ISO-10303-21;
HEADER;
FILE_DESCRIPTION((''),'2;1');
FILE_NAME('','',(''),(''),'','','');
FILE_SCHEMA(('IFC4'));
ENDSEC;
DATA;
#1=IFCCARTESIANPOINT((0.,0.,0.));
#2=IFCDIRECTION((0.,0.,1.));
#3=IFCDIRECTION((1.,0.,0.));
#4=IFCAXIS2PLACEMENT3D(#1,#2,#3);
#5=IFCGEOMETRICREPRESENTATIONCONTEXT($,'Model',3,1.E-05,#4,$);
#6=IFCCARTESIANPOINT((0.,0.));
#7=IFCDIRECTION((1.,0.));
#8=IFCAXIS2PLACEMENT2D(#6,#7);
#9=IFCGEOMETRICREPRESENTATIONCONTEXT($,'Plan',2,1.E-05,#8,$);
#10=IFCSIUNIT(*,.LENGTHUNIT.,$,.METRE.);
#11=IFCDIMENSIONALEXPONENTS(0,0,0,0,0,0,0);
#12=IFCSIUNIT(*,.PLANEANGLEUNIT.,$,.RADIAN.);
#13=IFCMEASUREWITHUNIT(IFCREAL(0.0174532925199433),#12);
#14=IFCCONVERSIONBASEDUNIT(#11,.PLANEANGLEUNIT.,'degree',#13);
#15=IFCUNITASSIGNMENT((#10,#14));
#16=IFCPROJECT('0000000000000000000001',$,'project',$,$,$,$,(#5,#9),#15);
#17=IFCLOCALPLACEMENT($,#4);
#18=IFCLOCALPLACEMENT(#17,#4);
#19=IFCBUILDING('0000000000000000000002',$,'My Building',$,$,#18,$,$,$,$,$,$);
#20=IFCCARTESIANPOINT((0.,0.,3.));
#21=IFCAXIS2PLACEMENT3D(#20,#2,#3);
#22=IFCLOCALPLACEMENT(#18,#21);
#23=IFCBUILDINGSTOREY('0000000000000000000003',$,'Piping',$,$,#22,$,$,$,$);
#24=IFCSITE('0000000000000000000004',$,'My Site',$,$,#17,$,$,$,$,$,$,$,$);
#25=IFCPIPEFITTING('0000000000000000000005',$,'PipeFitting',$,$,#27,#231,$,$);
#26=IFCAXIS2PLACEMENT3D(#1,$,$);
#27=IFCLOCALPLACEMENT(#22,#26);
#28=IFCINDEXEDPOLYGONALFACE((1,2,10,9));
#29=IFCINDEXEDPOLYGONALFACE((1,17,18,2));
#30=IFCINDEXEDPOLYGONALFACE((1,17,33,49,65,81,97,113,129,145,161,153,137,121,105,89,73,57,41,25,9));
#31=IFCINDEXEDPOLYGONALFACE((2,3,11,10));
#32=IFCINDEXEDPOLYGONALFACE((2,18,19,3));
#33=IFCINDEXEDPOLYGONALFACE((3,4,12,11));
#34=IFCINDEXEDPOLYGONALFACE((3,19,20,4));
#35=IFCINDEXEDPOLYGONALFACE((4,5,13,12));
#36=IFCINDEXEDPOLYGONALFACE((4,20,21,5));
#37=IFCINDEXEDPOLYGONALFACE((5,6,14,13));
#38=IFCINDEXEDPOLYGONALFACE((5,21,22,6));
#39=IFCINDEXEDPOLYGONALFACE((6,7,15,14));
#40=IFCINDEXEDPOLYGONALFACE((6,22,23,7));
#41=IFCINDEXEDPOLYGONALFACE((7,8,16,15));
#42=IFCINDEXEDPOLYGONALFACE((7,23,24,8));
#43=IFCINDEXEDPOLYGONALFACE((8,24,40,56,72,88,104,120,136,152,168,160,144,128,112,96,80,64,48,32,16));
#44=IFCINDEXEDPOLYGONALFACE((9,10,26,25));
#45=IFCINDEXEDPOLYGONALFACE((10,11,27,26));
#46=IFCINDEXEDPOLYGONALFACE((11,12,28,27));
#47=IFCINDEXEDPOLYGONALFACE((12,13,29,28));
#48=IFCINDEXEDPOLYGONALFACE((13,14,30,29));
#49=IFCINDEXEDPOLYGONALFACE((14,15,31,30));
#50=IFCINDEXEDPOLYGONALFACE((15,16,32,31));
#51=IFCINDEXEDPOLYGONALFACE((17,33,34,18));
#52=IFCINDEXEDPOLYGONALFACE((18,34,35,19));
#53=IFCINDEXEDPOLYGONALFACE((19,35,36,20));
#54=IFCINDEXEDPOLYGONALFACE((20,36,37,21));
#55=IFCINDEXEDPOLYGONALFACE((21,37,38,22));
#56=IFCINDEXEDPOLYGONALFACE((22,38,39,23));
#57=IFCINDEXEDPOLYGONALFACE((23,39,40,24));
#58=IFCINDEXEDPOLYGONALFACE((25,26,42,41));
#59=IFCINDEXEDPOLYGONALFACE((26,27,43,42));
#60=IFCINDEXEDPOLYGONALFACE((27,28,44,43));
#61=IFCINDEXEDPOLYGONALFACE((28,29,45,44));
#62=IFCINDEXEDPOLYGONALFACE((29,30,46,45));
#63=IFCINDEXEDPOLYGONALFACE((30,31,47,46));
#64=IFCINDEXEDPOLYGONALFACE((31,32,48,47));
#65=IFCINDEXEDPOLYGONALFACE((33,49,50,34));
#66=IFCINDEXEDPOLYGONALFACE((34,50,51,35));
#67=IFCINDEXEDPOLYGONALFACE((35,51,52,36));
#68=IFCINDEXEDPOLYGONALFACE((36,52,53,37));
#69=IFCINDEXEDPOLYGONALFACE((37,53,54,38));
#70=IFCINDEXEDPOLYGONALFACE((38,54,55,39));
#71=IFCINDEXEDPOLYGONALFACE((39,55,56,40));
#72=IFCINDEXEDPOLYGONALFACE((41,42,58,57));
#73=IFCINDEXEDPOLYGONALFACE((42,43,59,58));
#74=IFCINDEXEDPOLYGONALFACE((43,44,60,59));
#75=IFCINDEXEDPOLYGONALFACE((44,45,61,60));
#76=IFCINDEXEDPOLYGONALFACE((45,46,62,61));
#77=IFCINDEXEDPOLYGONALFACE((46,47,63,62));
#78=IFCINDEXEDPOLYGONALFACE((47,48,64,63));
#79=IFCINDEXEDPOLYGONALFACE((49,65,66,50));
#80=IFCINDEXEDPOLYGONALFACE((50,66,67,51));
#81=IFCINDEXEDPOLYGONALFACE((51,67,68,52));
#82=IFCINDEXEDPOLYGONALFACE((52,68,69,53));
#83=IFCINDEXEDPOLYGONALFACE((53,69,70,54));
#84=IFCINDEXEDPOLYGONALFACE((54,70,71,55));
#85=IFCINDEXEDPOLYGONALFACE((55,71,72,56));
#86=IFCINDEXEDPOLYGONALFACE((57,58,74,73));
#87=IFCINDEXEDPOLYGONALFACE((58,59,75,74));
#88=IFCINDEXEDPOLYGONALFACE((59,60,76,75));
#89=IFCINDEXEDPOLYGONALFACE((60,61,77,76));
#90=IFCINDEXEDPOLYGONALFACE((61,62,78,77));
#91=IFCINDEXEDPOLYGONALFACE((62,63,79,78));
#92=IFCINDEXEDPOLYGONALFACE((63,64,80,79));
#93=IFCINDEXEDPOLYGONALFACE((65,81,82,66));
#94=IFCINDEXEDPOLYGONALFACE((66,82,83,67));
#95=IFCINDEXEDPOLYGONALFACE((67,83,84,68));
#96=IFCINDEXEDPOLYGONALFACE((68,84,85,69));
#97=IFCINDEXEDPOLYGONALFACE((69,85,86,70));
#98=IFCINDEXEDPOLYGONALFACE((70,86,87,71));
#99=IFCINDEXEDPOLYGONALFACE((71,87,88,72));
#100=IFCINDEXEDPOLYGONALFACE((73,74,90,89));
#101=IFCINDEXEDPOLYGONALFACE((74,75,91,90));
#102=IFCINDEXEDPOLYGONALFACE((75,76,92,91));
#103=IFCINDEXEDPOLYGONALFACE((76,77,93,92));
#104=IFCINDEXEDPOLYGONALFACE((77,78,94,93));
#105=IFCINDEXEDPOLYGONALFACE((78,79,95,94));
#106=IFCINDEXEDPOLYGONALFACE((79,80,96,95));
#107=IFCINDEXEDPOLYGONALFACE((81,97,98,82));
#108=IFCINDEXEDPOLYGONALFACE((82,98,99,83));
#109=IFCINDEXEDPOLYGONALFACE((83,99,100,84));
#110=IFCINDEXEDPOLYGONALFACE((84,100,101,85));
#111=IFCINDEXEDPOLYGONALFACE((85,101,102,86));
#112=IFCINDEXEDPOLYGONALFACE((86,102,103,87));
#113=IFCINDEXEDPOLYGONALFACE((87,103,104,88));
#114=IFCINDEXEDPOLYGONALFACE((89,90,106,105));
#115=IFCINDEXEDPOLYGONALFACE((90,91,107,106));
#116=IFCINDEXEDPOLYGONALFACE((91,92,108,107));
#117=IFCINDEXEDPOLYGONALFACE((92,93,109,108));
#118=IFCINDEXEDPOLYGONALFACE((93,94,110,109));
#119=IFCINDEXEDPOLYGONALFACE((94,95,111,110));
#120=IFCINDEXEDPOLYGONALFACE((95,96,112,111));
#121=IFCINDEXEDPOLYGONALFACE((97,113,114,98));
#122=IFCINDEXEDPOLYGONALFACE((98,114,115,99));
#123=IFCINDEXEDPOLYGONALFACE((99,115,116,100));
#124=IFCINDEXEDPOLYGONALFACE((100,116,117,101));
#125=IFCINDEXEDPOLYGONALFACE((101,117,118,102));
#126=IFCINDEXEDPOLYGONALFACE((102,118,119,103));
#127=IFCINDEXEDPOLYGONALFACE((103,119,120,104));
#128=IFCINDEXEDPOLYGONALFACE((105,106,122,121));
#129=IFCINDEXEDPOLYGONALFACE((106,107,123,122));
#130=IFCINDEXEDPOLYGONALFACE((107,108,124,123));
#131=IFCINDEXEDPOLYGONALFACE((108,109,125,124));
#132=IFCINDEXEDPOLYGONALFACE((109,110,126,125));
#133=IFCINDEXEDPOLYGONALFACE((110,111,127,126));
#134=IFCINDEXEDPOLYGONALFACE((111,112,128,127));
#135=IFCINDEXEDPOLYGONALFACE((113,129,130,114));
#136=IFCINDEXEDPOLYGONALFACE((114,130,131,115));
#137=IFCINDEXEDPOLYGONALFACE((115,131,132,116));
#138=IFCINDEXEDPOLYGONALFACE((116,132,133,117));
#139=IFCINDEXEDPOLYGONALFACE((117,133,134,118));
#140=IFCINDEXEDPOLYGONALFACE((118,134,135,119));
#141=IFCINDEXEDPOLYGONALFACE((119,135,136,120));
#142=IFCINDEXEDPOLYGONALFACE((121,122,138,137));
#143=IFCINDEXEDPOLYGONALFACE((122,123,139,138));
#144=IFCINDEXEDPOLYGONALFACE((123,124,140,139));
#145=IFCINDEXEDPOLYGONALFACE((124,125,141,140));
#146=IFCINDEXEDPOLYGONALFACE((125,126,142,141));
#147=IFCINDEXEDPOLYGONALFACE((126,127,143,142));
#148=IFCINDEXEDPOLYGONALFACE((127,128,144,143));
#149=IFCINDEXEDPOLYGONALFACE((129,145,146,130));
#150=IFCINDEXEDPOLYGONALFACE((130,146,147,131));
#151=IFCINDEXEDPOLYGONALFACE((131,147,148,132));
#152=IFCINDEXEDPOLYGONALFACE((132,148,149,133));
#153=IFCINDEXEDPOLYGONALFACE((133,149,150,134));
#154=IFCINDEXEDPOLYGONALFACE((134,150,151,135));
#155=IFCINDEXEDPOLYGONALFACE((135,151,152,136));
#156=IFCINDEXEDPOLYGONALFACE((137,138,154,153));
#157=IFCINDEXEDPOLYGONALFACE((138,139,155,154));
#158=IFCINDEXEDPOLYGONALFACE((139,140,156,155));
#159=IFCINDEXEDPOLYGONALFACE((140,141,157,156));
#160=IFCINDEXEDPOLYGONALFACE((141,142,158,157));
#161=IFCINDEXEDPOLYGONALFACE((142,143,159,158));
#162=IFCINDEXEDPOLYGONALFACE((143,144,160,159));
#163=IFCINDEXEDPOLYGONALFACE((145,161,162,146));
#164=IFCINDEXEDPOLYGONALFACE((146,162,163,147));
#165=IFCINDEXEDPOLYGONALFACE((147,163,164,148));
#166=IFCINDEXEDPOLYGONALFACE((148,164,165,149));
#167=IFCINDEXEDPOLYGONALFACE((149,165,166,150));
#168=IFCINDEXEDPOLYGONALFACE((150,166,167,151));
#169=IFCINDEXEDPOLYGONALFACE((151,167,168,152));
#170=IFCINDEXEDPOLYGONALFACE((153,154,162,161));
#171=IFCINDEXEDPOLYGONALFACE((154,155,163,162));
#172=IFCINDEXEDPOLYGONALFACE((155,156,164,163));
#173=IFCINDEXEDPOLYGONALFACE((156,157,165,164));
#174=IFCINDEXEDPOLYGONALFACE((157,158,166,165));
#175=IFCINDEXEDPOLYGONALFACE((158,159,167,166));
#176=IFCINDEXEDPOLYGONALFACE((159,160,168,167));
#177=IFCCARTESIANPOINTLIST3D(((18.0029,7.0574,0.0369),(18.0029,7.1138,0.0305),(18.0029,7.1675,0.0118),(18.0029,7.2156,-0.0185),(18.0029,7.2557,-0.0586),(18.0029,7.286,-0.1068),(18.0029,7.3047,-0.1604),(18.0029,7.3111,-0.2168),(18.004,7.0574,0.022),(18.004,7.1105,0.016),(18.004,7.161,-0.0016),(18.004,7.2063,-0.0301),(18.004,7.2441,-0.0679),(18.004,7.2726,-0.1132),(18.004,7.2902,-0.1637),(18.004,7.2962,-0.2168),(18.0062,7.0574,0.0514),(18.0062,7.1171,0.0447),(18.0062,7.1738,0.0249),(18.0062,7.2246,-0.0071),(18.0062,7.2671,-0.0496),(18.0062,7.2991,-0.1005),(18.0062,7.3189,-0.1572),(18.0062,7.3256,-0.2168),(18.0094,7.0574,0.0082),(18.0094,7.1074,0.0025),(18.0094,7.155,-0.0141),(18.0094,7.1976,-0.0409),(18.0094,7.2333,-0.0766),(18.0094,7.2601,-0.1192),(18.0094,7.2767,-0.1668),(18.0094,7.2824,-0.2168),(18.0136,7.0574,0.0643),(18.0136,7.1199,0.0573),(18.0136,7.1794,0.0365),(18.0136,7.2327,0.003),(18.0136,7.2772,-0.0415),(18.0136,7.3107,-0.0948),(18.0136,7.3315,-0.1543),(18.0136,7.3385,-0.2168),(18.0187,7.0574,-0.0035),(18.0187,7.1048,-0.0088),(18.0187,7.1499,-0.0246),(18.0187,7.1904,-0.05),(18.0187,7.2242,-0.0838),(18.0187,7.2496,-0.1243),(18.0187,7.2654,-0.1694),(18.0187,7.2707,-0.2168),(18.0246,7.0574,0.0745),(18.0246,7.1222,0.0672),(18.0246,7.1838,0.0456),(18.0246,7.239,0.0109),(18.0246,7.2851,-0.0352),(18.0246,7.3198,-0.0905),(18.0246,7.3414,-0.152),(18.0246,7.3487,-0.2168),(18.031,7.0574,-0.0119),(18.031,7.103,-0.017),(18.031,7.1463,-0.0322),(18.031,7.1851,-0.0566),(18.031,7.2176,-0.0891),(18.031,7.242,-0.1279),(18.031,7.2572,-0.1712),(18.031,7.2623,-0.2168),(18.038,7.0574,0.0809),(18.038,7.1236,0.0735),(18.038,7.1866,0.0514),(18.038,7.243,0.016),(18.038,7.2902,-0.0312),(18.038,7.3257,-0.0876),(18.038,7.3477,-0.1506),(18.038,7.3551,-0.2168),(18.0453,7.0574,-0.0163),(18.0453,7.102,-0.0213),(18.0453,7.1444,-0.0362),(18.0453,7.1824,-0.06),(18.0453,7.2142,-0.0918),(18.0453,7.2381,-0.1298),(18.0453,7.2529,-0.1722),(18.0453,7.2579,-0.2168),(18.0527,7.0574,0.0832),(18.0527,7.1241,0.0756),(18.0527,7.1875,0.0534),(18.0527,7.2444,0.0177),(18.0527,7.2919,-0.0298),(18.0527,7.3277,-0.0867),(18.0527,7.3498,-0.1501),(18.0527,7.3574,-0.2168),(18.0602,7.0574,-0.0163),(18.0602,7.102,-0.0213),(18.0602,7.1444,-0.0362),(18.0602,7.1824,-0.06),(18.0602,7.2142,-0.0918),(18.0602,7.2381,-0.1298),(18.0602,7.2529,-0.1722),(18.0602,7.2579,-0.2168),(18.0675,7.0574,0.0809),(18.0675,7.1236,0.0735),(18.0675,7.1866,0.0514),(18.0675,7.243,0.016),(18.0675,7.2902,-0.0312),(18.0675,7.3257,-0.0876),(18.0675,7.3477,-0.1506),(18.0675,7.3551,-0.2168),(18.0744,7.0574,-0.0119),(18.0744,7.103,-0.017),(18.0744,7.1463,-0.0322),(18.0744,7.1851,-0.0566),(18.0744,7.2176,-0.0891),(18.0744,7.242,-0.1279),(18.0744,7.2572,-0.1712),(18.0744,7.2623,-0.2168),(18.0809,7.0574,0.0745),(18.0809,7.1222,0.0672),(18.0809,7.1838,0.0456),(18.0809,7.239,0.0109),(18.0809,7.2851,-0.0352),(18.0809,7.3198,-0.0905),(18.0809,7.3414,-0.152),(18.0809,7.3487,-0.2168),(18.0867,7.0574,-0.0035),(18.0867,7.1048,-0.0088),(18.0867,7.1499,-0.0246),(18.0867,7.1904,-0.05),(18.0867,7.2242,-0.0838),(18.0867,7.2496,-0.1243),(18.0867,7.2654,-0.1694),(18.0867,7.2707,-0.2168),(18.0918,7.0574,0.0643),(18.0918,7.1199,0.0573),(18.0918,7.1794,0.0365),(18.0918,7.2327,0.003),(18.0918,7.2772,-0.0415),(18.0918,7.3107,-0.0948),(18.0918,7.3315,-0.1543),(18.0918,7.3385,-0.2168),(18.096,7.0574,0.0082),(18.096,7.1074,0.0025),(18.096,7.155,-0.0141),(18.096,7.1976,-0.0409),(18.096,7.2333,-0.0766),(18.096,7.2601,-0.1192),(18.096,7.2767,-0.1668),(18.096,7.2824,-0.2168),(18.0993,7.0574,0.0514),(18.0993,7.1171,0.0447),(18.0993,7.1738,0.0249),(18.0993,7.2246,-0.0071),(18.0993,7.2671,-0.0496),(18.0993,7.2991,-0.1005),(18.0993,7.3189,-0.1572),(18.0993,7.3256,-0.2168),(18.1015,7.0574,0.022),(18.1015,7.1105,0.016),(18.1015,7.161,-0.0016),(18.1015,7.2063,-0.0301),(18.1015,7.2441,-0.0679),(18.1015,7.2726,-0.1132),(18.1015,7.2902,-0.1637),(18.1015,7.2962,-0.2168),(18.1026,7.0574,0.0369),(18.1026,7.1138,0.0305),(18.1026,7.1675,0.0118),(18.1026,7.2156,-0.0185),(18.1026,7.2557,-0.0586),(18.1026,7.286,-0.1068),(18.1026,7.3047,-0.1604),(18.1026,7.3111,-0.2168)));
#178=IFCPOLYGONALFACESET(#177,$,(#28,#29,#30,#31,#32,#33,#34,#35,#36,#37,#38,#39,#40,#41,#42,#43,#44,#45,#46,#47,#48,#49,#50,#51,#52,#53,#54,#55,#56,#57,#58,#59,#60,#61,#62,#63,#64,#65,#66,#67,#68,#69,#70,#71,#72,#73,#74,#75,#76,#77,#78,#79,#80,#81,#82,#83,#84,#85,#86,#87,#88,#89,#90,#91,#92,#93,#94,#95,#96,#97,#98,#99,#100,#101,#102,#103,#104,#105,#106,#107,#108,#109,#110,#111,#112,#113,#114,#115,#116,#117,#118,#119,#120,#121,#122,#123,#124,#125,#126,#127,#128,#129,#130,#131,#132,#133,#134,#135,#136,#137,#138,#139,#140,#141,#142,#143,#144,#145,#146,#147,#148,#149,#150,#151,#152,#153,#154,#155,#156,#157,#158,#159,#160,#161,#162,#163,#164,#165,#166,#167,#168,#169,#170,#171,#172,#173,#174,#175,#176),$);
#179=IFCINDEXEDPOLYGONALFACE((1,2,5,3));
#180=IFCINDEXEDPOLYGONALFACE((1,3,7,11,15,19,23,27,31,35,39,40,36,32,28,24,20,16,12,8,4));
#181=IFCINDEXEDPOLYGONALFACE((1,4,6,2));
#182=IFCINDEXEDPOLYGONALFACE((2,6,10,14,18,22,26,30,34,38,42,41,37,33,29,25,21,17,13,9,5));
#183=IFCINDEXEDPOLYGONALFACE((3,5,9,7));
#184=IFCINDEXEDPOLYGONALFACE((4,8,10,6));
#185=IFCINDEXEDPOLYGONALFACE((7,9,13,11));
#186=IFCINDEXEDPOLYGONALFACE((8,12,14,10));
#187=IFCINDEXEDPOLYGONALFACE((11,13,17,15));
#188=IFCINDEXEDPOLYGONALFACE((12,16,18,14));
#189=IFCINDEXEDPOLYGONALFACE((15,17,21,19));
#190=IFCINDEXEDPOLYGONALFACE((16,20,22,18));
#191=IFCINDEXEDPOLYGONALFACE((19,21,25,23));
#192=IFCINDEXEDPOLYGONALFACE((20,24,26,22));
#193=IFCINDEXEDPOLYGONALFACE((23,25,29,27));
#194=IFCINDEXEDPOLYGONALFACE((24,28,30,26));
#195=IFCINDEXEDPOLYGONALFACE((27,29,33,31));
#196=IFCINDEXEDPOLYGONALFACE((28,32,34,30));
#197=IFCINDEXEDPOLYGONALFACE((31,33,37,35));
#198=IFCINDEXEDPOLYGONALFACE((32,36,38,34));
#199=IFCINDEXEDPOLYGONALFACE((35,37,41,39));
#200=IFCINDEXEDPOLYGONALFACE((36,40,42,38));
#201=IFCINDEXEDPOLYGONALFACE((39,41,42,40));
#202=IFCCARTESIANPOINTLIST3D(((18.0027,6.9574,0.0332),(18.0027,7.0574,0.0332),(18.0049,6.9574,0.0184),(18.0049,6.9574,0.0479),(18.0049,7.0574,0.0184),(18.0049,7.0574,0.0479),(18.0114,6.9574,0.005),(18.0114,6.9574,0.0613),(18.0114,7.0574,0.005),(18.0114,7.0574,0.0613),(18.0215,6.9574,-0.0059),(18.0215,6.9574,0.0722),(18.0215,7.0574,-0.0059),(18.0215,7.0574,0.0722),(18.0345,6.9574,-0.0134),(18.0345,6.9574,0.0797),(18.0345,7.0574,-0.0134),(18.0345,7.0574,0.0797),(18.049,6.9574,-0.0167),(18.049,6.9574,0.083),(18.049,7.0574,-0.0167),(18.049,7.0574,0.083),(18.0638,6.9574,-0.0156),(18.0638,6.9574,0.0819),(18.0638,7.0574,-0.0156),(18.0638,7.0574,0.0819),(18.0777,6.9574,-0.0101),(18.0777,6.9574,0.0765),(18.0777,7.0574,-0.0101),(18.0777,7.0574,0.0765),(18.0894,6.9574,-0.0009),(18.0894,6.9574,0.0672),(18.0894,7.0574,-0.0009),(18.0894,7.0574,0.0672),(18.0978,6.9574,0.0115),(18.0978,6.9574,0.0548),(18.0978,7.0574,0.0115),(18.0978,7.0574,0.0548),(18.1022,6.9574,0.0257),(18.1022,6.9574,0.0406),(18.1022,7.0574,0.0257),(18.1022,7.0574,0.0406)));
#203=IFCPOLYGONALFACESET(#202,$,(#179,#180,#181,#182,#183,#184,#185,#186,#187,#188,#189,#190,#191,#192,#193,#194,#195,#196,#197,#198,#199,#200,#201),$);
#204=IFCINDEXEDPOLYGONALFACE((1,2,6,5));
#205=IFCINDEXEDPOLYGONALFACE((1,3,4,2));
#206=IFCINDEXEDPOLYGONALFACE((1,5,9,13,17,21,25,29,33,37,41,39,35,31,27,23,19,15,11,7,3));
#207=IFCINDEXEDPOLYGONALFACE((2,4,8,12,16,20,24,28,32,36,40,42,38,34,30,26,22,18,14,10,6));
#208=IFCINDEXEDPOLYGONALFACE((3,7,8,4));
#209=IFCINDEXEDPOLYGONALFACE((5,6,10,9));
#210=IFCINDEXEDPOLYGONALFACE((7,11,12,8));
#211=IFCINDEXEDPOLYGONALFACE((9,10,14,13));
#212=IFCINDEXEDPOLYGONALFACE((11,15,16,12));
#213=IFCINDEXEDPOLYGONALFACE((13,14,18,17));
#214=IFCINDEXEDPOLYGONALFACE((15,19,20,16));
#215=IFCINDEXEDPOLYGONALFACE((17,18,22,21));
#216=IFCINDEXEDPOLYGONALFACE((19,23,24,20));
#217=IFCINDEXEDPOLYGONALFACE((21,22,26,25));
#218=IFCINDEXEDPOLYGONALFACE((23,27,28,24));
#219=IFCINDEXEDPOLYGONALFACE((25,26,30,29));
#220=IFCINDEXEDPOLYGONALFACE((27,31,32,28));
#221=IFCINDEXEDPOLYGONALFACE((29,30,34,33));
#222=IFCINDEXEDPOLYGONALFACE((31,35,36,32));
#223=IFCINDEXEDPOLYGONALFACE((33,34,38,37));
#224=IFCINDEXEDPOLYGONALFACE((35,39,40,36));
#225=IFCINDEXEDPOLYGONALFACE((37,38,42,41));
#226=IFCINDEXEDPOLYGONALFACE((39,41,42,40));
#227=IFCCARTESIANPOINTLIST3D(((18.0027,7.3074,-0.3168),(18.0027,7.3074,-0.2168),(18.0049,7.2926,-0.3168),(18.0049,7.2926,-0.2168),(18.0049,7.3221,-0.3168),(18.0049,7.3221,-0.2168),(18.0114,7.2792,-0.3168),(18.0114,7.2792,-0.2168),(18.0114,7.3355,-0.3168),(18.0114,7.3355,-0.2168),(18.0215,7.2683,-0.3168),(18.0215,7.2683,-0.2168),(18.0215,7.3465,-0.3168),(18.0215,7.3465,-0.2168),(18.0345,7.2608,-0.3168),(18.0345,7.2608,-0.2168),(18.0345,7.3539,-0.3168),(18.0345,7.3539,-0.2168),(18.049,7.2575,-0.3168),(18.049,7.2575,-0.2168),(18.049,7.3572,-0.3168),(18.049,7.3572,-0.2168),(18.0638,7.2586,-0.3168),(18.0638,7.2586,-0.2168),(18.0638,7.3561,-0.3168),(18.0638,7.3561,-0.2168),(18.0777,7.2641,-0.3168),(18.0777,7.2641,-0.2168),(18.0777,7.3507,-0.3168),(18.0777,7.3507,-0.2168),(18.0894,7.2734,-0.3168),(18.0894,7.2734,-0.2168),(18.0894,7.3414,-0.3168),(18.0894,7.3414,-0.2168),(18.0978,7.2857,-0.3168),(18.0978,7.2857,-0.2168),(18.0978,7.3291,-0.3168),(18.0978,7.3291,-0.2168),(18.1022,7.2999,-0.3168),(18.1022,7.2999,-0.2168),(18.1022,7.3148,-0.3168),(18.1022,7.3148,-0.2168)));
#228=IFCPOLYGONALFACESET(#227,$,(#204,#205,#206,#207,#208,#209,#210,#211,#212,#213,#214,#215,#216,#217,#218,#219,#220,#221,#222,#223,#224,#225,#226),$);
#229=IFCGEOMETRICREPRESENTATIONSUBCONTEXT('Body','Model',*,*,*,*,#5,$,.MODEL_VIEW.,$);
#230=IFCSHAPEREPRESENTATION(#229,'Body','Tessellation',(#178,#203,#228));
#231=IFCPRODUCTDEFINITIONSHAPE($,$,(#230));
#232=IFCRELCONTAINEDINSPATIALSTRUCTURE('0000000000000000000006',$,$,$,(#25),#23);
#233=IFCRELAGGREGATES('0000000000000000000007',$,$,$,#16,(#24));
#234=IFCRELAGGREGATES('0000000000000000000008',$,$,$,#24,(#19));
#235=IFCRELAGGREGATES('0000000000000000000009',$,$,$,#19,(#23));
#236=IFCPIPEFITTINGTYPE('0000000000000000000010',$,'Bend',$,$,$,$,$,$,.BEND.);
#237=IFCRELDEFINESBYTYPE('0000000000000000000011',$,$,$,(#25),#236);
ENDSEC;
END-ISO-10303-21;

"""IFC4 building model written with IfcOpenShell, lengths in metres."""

from ifc_helpers import new_model, entity, si_unit, converted_unit, frame, origin_with_axes, origin_2d_with_axis, place, context, subcontext, project, spatial, circle, extrude, source, transform, mapped, type_object, type_shapes, element, save


model = new_model("IFC4")

# Units and contexts
model_context = context("Model", 3, precision=1e-05, world=origin_with_axes())
plan_context = context("Plan", 2, precision=1e-05, world=origin_2d_with_axis())
body_context = subcontext(model_context, "Body", "Model", "MODEL_VIEW")
ifc_project = project(units=[si_unit("LENGTHUNIT", "METRE"), converted_unit("PLANEANGLEUNIT", "degree", entity("IfcReal", 0.0174532925199433), si_unit("PLANEANGLEUNIT", "RADIAN"), dimensions=[0, 0, 0, 0, 0, 0, 0])], contexts=[model_context, plan_context])

# Site, building, storey
site_placement = place(None, origin_with_axes())
site = spatial("IfcSite", under=ifc_project, at=site_placement, Name="My Site")
building_placement = place(site_placement, origin_with_axes())
building = spatial("IfcBuilding", under=site, at=building_placement, Name="My Building")
storey_placement = place(building_placement, frame((0.0, 0.0, 3.0), z_axis=(0.0, 0.0, 1.0), x_axis=(1.0, 0.0, 0.0)))
storey = spatial("IfcBuildingStorey", under=building, at=storey_placement, Name="Piping")

# Pipe fitting
pipe_fitting_type = type_object("IfcPipeFittingType", Name="Bend", PredefinedType="BEND")
shared_shape = source(origin_with_axes(), body_context, "Body", "SolidModel", [
    entity("IfcSweptDiskSolid", entity("IfcIndexedPolyCurve", entity("IfcCartesianPointList3D", [[0.0, 0.0, -0.1], [0.0, 0.0732, -0.2768], [0.0, 0.25, -0.35]]), [entity("IfcArcIndex", [1, 2, 3])]), 0.05),
    extrude(circle(Radius=0.05), origin_with_axes(), (0.0, 0.0, -1.0), 0.1),
    extrude(circle(Radius=0.05), frame((0.0, 0.25, -0.35), z_axis=(0.0, 1.0, 0.0), x_axis=(1.0, 0.0, 0.0)), (0.0, 0.0, 1.0), 0.1),
])
type_shapes(pipe_fitting_type, [shared_shape])
for number, where, z_axis, x_axis, name in (
    (1, (18.0527, 6.9574, 0.0332), (0.0, -1.0, 0.0), (-1.0, 0.0, 0.0), "PipeFitting"),
):
    element("IfcPipeFitting", number, at=place(storey_placement, frame(where, z_axis=z_axis, x_axis=x_axis)), inside=storey, type_object=pipe_fitting_type, Name=name, context=body_context, shape_type="MappedRepresentation", body=[
        mapped(shared_shape, transform((0.0, 0.0, 0.0), x_axis=(1.0, 0.0, 0.0), y_axis=(0.0, 1.0, 0.0), z_axis=(0.0, 0.0, 1.0), scale=1.0)),
    ])

save(model, "model.ifc")
